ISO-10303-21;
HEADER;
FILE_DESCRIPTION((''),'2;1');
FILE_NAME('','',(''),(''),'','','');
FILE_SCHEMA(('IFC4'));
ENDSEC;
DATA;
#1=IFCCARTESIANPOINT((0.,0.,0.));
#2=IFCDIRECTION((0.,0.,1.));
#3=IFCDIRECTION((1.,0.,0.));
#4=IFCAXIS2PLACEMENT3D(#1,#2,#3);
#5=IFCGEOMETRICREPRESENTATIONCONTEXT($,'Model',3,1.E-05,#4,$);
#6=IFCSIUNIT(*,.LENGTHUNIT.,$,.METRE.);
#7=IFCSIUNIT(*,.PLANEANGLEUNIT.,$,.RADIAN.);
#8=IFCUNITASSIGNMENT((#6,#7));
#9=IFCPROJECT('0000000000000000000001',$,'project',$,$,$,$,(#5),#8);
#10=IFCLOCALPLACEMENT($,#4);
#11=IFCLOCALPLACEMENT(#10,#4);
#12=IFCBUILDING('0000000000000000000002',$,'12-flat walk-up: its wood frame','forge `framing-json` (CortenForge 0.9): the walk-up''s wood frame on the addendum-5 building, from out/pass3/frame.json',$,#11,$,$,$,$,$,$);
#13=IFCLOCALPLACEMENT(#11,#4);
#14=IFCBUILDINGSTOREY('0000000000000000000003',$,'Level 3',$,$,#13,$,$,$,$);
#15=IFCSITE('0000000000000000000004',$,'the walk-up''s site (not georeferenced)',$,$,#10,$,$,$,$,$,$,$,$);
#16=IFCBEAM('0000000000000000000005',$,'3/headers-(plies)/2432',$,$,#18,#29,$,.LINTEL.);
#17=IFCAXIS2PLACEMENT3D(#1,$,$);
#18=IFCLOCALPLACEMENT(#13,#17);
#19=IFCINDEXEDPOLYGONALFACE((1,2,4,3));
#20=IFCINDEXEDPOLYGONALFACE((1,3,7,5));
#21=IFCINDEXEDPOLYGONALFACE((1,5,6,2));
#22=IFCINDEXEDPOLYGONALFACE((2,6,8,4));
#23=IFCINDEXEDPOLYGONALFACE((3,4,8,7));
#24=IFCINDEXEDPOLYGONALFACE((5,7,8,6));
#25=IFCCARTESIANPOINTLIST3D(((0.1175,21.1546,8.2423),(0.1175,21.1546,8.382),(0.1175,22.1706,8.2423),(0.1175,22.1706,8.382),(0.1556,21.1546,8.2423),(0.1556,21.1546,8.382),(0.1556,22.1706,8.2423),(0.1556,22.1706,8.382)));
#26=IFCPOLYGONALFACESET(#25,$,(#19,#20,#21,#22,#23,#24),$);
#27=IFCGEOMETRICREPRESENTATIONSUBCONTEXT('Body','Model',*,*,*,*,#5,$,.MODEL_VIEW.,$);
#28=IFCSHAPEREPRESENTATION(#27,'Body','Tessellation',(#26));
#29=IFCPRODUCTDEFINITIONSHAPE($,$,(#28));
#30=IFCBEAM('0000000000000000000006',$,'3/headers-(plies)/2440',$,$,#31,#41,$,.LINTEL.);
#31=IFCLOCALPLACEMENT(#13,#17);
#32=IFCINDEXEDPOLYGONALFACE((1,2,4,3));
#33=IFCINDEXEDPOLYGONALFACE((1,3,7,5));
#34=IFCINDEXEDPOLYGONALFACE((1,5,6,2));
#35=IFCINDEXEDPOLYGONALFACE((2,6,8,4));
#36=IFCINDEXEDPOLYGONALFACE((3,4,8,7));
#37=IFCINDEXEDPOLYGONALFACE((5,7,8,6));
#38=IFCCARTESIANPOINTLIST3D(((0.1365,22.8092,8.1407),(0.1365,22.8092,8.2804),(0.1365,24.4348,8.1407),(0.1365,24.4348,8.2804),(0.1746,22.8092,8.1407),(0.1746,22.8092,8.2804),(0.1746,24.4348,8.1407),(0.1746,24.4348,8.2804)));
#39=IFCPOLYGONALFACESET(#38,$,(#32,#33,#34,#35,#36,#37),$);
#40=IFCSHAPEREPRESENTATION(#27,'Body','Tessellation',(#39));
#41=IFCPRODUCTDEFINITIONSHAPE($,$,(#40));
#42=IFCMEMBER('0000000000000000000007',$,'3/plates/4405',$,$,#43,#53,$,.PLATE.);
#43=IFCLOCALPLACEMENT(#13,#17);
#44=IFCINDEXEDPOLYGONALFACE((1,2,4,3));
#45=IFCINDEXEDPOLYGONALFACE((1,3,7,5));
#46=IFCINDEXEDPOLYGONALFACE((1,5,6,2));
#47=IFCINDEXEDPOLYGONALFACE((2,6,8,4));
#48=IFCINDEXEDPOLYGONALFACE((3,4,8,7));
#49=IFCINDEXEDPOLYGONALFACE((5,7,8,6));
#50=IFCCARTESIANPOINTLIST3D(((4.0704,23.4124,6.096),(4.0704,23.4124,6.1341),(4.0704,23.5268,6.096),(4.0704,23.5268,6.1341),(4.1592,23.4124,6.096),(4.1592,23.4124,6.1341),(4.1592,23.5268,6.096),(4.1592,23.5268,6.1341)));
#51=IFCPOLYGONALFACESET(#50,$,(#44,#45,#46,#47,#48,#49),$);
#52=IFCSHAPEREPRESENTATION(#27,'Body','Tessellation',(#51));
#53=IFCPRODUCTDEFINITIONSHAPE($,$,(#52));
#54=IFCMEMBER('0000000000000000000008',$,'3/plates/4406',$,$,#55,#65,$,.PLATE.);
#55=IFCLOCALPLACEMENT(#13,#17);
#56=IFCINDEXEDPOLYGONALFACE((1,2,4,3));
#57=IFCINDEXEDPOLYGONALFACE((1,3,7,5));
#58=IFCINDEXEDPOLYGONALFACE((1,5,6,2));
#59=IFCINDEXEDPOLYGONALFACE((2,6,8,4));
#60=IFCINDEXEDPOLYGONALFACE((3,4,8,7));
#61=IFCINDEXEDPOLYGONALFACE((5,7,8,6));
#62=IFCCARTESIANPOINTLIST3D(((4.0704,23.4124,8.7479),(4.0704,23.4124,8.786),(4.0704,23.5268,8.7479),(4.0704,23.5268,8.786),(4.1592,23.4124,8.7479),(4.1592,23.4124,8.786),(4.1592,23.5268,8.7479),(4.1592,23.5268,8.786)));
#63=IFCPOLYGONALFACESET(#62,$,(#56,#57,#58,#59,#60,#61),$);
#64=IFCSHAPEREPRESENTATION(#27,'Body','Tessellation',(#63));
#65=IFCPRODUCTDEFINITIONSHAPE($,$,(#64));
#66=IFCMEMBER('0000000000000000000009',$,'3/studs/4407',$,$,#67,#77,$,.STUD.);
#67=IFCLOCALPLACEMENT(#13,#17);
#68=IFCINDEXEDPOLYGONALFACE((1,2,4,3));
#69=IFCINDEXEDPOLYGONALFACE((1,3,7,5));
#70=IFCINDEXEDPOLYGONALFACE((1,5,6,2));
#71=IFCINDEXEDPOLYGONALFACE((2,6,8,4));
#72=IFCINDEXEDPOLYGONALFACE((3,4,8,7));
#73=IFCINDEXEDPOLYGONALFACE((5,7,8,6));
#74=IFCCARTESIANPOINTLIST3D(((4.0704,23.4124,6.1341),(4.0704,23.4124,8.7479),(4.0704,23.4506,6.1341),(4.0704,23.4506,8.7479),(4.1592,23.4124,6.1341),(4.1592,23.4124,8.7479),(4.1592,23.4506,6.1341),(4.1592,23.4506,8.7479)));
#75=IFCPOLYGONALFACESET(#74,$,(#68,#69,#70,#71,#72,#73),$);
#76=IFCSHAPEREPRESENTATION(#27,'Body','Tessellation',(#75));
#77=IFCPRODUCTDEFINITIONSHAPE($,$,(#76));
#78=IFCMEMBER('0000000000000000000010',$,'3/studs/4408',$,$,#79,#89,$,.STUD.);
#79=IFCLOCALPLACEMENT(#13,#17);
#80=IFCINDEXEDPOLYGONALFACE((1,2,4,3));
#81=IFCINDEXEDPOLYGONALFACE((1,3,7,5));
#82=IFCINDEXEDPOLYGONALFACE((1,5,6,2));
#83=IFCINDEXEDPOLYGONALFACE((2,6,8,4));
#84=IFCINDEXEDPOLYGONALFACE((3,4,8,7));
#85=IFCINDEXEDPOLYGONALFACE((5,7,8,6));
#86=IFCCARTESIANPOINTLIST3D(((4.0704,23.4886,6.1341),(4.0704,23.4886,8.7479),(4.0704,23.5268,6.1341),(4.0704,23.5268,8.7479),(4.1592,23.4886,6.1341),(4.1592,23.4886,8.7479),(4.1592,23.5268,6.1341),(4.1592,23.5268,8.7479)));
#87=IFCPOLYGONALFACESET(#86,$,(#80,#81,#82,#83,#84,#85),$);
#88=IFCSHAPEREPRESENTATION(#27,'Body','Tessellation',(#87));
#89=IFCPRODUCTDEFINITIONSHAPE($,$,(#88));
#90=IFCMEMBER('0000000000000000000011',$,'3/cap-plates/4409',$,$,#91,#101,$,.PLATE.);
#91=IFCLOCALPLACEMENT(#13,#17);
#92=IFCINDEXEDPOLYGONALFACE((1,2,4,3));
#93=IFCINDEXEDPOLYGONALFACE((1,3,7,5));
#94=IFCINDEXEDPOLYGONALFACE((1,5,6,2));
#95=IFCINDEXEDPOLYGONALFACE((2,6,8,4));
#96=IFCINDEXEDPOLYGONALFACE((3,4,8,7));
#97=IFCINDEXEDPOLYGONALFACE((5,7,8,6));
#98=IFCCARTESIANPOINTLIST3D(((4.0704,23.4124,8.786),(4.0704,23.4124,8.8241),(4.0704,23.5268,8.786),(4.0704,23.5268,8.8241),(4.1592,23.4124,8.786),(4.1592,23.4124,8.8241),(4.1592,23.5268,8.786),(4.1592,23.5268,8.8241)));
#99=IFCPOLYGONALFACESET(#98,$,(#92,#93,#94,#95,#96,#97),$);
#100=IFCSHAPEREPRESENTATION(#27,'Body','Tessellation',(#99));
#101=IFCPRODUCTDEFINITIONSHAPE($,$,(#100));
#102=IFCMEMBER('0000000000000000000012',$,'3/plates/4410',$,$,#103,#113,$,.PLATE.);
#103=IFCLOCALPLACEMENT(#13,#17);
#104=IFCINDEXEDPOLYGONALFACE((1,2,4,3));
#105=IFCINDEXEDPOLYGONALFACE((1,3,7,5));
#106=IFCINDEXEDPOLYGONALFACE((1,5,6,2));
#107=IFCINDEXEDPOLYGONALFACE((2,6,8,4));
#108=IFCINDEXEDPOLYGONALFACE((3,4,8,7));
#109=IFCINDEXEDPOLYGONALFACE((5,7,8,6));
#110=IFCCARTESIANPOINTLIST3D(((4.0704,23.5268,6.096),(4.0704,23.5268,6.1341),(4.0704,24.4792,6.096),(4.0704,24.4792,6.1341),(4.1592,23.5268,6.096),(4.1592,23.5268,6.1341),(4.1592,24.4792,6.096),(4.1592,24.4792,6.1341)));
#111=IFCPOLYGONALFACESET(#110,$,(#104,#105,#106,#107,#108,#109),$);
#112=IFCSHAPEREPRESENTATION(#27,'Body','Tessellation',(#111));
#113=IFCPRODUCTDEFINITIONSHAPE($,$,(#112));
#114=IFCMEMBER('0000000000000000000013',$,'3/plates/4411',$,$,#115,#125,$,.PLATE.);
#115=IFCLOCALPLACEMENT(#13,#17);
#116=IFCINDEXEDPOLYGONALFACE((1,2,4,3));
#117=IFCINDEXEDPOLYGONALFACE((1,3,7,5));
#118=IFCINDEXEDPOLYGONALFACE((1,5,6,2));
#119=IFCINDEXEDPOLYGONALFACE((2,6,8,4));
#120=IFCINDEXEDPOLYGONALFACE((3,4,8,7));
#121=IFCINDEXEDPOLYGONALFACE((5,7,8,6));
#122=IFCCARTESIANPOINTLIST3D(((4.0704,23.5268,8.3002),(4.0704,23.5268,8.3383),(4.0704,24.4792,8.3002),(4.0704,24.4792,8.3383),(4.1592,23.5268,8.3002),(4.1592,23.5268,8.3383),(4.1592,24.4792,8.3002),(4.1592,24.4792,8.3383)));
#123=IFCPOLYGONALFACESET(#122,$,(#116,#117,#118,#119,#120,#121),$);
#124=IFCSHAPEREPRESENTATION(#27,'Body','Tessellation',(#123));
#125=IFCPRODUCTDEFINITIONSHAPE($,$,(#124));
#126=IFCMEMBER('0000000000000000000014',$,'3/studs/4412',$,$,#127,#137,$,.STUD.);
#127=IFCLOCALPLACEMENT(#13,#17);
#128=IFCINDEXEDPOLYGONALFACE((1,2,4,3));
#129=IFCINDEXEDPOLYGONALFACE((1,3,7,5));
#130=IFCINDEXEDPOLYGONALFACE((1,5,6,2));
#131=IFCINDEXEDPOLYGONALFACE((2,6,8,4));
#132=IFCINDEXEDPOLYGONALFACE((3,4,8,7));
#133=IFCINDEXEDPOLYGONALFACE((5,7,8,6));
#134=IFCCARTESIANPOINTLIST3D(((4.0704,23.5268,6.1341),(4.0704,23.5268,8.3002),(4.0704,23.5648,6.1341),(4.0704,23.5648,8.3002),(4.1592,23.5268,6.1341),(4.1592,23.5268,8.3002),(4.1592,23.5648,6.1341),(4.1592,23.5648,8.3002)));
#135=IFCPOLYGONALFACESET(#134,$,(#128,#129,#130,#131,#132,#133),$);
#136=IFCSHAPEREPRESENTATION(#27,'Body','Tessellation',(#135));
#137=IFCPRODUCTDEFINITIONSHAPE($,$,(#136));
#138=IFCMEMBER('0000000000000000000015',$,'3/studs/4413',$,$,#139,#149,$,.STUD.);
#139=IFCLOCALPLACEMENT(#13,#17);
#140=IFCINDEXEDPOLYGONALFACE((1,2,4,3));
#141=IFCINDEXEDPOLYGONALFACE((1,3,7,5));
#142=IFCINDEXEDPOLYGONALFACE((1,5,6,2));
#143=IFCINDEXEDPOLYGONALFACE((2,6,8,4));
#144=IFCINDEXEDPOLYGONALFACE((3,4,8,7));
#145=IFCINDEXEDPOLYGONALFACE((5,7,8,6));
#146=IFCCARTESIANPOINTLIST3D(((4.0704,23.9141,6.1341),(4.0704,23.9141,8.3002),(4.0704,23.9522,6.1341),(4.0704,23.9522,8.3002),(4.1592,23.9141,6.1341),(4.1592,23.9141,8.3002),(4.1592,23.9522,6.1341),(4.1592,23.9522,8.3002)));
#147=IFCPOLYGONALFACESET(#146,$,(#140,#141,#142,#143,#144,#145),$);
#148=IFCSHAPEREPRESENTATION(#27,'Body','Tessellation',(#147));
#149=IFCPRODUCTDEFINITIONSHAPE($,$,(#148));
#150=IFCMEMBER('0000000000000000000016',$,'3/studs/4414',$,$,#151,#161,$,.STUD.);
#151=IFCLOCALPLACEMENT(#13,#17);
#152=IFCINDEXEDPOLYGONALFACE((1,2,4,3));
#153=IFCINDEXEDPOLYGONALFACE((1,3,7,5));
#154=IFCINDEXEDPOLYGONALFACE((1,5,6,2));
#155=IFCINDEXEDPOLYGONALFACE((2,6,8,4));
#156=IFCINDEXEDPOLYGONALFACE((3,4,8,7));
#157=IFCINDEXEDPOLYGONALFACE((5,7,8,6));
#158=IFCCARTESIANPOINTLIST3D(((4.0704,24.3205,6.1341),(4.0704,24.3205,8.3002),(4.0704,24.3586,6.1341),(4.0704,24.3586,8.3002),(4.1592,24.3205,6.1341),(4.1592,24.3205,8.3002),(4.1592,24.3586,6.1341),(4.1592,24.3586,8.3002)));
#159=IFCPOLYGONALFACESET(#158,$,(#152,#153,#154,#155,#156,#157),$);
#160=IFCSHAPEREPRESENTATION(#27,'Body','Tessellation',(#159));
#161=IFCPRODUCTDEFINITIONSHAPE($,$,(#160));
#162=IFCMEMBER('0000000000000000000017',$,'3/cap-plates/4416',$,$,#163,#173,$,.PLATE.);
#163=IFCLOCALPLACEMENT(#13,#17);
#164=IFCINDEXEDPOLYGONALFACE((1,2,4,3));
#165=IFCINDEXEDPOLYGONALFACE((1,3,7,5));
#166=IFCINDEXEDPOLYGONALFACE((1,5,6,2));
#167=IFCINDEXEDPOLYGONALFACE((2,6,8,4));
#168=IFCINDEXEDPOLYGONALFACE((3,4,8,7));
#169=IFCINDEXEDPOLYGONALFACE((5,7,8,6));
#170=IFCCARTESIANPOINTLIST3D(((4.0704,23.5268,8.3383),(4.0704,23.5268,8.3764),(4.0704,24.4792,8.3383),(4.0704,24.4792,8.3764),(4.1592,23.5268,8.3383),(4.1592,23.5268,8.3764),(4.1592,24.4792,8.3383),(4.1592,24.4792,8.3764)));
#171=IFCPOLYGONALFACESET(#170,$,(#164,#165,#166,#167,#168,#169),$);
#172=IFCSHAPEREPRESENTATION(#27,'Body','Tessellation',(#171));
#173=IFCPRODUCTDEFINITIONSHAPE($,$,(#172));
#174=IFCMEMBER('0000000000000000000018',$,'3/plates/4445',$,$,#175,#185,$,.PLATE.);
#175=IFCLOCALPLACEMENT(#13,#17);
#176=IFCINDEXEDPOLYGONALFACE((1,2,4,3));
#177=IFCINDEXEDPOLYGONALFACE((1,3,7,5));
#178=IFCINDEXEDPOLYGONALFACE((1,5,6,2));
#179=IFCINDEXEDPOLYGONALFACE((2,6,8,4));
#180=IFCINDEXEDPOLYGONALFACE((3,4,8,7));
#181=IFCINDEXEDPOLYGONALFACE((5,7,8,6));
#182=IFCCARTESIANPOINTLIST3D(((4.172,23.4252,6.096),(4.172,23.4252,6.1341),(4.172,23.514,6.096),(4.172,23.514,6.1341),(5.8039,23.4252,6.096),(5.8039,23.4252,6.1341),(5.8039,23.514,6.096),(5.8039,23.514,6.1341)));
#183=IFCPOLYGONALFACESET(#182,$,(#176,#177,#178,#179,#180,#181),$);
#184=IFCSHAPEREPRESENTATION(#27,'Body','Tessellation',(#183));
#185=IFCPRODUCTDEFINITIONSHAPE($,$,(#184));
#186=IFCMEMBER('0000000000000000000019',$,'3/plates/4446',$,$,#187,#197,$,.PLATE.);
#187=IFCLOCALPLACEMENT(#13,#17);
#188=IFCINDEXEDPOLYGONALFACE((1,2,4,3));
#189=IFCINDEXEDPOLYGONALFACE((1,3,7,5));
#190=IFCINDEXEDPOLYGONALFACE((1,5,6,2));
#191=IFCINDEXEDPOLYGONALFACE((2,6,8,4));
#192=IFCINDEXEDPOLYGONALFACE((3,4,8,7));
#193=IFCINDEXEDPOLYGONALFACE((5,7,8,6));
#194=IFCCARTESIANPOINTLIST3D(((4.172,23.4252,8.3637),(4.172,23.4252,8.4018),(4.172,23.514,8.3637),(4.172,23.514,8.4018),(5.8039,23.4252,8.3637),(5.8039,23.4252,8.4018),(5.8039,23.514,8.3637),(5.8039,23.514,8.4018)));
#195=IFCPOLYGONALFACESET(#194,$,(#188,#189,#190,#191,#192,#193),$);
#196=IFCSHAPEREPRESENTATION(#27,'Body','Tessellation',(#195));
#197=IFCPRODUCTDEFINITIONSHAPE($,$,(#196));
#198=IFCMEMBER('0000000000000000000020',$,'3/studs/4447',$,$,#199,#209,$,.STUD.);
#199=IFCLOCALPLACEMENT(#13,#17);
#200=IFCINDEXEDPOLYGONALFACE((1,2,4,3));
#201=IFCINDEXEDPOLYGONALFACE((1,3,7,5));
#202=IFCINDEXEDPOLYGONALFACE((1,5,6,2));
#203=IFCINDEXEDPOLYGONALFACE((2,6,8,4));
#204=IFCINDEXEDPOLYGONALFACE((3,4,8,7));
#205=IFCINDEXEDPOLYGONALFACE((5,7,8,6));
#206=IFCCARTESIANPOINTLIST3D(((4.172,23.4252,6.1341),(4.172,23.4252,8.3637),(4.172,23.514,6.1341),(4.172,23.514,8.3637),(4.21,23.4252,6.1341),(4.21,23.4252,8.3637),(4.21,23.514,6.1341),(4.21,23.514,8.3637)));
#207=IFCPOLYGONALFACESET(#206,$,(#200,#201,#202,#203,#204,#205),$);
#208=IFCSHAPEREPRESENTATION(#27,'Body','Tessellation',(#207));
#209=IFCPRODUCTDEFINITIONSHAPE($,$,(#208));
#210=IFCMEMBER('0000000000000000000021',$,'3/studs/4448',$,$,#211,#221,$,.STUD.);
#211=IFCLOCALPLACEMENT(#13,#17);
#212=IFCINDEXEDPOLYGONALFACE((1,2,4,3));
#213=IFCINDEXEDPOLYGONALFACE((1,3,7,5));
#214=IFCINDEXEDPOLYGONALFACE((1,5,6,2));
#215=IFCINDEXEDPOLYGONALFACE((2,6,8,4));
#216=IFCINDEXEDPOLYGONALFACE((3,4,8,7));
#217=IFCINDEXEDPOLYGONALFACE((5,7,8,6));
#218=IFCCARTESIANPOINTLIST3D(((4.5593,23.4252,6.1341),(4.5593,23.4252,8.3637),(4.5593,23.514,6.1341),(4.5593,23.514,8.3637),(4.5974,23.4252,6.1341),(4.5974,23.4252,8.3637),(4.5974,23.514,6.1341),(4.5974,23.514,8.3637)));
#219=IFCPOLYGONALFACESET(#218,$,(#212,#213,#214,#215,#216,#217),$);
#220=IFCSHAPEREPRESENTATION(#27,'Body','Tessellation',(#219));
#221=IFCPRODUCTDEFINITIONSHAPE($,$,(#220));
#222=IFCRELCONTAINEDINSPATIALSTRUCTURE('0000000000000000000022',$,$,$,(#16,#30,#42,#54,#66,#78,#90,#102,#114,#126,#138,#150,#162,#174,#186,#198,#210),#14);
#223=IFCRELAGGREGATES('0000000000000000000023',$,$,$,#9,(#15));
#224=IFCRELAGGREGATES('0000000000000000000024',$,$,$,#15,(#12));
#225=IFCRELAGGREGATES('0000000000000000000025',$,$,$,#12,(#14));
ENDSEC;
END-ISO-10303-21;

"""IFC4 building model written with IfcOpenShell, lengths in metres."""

from ifc_helpers import new_model, si_unit, frame, frame_2d, origin, origin_with_axes, place, context, subcontext, project, spatial, rectangle, extrude, element, save


model = new_model("IFC4")

# Units and contexts
model_context = context("Model", 3, precision=1e-05, world=origin_with_axes())
body_context = subcontext(model_context, "Body", "Model", "MODEL_VIEW")
ifc_project = project(units=[si_unit("LENGTHUNIT", "METRE"), si_unit("PLANEANGLEUNIT", "RADIAN")], contexts=[model_context])

# Site, building, storey
site_placement = place(None, origin_with_axes())
site = spatial("IfcSite", under=ifc_project, at=site_placement, Name="the walk-up's site (not georeferenced)")
building_placement = place(site_placement, origin_with_axes())
building = spatial("IfcBuilding", under=site, at=building_placement, Name="12-flat walk-up: its wood frame", Description="forge `framing-json` (CortenForge 0.9): the walk-up's wood frame on the addendum-5 building, from out/pass3/frame.json")
storey_placement = place(building_placement, origin_with_axes())
storey = spatial("IfcBuildingStorey", under=building, at=storey_placement, Name="Level 3")

# Beams
beam_1_placement = place(storey_placement, frame((0.1175, 21.1546, 8.2423), z_axis=(0.0, 0.0, 1.0), x_axis=(1.0, 0.0, 0.0)))
element("IfcBeam", 1, at=beam_1_placement, inside=storey, Name="3/headers-(plies)/2432", PredefinedType="LINTEL", context=body_context, shape_type="SweptSolid", body=[
    extrude(rectangle(XDim=0.0381, YDim=1.016, at=frame_2d((0.019, 0.508))), origin(), (0.0, 0.0, 1.0), 0.1397),
])
beam_2_placement = place(storey_placement, frame((0.1365, 22.8092, 8.1407), z_axis=(0.0, 0.0, 1.0), x_axis=(1.0, 0.0, 0.0)))
element("IfcBeam", 2, at=beam_2_placement, inside=storey, Name="3/headers-(plies)/2440", PredefinedType="LINTEL", context=body_context, shape_type="SweptSolid", body=[
    extrude(rectangle(XDim=0.0381, YDim=1.6256, at=frame_2d((0.019, 0.8128))), origin(), (0.0, 0.0, 1.0), 0.1397),
])

# Members
for number, where, z_axis, x_axis, name in (
    (3, (4.0704, 23.4124, 6.096), (0.0, 0.0, 1.0), (1.0, 0.0, 0.0), "3/plates/4405"),
    (4, (4.0704, 23.4124, 8.7479), (0.0, 0.0, 1.0), (1.0, 0.0, 0.0), "3/plates/4406"),
):
    element("IfcMember", number, at=place(storey_placement, frame(where, z_axis=z_axis, x_axis=x_axis)), inside=storey, Name=name, PredefinedType="PLATE", context=body_context, shape_type="SweptSolid", body=[
        extrude(rectangle(XDim=0.0889, YDim=0.1143, at=frame_2d((0.0444, 0.0572))), origin(), (0.0, 0.0, 1.0), 0.0381),
    ])
for number, where, z_axis, x_axis, name in (
    (5, (4.0704, 23.4124, 6.1341), (0.0, 0.0, 1.0), (1.0, 0.0, 0.0), "3/studs/4407"),
    (6, (4.0704, 23.4886, 6.1341), (0.0, 0.0, 1.0), (1.0, 0.0, 0.0), "3/studs/4408"),
):
    element("IfcMember", number, at=place(storey_placement, frame(where, z_axis=z_axis, x_axis=x_axis)), inside=storey, Name=name, PredefinedType="STUD", context=body_context, shape_type="SweptSolid", body=[
        extrude(rectangle(XDim=0.0889, YDim=0.0381, at=frame_2d((0.0444, 0.0191))), origin(), (0.0, 0.0, 1.0), 2.6138),
    ])
member_1_placement = place(storey_placement, frame((4.0704, 23.4124, 8.786), z_axis=(0.0, 0.0, 1.0), x_axis=(1.0, 0.0, 0.0)))
element("IfcMember", 7, at=member_1_placement, inside=storey, Name="3/cap-plates/4409", PredefinedType="PLATE", context=body_context, shape_type="SweptSolid", body=[
    extrude(rectangle(XDim=0.0889, YDim=0.1143, at=frame_2d((0.0444, 0.0572))), origin(), (0.0, 0.0, 1.0), 0.0381),
])
for number, where, z_axis, x_axis, name in (
    (8, (4.0704, 23.5267, 6.096), (0.0, 0.0, 1.0), (1.0, 0.0, 0.0), "3/plates/4410"),
    (9, (4.0704, 23.5267, 8.3002), (0.0, 0.0, 1.0), (1.0, 0.0, 0.0), "3/plates/4411"),
):
    element("IfcMember", number, at=place(storey_placement, frame(where, z_axis=z_axis, x_axis=x_axis)), inside=storey, Name=name, PredefinedType="PLATE", context=body_context, shape_type="SweptSolid", body=[
        extrude(rectangle(XDim=0.0889, YDim=0.9525, at=frame_2d((0.0444, 0.4763))), origin(), (0.0, 0.0, 1.0), 0.0381),
    ])
for number, where, z_axis, x_axis, name in (
    (10, (4.0704, 23.5267, 6.1341), (0.0, 0.0, 1.0), (1.0, 0.0, 0.0), "3/studs/4412"),
    (11, (4.0704, 23.9141, 6.1341), (0.0, 0.0, 1.0), (1.0, 0.0, 0.0), "3/studs/4413"),
    (12, (4.0704, 24.3205, 6.1341), (0.0, 0.0, 1.0), (1.0, 0.0, 0.0), "3/studs/4414"),
):
    element("IfcMember", number, at=place(storey_placement, frame(where, z_axis=z_axis, x_axis=x_axis)), inside=storey, Name=name, PredefinedType="STUD", context=body_context, shape_type="SweptSolid", body=[
        extrude(rectangle(XDim=0.0889, YDim=0.0381, at=frame_2d((0.0444, 0.0191))), origin(), (0.0, 0.0, 1.0), 2.1661),
    ])
member_2_placement = place(storey_placement, frame((4.0704, 23.5267, 8.3383), z_axis=(0.0, 0.0, 1.0), x_axis=(1.0, 0.0, 0.0)))
element("IfcMember", 13, at=member_2_placement, inside=storey, Name="3/cap-plates/4416", PredefinedType="PLATE", context=body_context, shape_type="SweptSolid", body=[
    extrude(rectangle(XDim=0.0889, YDim=0.9525, at=frame_2d((0.0444, 0.4763))), origin(), (0.0, 0.0, 1.0), 0.0381),
])
for number, where, z_axis, x_axis, name in (
    (14, (4.1719, 23.4251, 6.096), (0.0, 0.0, 1.0), (1.0, 0.0, 0.0), "3/plates/4445"),
    (15, (4.1719, 23.4251, 8.3637), (0.0, 0.0, 1.0), (1.0, 0.0, 0.0), "3/plates/4446"),
):
    element("IfcMember", number, at=place(storey_placement, frame(where, z_axis=z_axis, x_axis=x_axis)), inside=storey, Name=name, PredefinedType="PLATE", context=body_context, shape_type="SweptSolid", body=[
        extrude(rectangle(XDim=1.6319, YDim=0.0889, at=frame_2d((0.816, 0.0445))), origin(), (0.0, 0.0, 1.0), 0.0381),
    ])
for number, where, z_axis, x_axis, name in (
    (16, (4.1719, 23.4251, 6.1341), (0.0, 0.0, 1.0), (1.0, 0.0, 0.0), "3/studs/4447"),
    (17, (4.5593, 23.4251, 6.1341), (0.0, 0.0, 1.0), (1.0, 0.0, 0.0), "3/studs/4448"),
):
    element("IfcMember", number, at=place(storey_placement, frame(where, z_axis=z_axis, x_axis=x_axis)), inside=storey, Name=name, PredefinedType="STUD", context=body_context, shape_type="SweptSolid", body=[
        extrude(rectangle(XDim=0.0381, YDim=0.0889, at=frame_2d((0.0191, 0.0445))), origin(), (0.0, 0.0, 1.0), 2.2296),
    ])

save(model, "model.ifc")
